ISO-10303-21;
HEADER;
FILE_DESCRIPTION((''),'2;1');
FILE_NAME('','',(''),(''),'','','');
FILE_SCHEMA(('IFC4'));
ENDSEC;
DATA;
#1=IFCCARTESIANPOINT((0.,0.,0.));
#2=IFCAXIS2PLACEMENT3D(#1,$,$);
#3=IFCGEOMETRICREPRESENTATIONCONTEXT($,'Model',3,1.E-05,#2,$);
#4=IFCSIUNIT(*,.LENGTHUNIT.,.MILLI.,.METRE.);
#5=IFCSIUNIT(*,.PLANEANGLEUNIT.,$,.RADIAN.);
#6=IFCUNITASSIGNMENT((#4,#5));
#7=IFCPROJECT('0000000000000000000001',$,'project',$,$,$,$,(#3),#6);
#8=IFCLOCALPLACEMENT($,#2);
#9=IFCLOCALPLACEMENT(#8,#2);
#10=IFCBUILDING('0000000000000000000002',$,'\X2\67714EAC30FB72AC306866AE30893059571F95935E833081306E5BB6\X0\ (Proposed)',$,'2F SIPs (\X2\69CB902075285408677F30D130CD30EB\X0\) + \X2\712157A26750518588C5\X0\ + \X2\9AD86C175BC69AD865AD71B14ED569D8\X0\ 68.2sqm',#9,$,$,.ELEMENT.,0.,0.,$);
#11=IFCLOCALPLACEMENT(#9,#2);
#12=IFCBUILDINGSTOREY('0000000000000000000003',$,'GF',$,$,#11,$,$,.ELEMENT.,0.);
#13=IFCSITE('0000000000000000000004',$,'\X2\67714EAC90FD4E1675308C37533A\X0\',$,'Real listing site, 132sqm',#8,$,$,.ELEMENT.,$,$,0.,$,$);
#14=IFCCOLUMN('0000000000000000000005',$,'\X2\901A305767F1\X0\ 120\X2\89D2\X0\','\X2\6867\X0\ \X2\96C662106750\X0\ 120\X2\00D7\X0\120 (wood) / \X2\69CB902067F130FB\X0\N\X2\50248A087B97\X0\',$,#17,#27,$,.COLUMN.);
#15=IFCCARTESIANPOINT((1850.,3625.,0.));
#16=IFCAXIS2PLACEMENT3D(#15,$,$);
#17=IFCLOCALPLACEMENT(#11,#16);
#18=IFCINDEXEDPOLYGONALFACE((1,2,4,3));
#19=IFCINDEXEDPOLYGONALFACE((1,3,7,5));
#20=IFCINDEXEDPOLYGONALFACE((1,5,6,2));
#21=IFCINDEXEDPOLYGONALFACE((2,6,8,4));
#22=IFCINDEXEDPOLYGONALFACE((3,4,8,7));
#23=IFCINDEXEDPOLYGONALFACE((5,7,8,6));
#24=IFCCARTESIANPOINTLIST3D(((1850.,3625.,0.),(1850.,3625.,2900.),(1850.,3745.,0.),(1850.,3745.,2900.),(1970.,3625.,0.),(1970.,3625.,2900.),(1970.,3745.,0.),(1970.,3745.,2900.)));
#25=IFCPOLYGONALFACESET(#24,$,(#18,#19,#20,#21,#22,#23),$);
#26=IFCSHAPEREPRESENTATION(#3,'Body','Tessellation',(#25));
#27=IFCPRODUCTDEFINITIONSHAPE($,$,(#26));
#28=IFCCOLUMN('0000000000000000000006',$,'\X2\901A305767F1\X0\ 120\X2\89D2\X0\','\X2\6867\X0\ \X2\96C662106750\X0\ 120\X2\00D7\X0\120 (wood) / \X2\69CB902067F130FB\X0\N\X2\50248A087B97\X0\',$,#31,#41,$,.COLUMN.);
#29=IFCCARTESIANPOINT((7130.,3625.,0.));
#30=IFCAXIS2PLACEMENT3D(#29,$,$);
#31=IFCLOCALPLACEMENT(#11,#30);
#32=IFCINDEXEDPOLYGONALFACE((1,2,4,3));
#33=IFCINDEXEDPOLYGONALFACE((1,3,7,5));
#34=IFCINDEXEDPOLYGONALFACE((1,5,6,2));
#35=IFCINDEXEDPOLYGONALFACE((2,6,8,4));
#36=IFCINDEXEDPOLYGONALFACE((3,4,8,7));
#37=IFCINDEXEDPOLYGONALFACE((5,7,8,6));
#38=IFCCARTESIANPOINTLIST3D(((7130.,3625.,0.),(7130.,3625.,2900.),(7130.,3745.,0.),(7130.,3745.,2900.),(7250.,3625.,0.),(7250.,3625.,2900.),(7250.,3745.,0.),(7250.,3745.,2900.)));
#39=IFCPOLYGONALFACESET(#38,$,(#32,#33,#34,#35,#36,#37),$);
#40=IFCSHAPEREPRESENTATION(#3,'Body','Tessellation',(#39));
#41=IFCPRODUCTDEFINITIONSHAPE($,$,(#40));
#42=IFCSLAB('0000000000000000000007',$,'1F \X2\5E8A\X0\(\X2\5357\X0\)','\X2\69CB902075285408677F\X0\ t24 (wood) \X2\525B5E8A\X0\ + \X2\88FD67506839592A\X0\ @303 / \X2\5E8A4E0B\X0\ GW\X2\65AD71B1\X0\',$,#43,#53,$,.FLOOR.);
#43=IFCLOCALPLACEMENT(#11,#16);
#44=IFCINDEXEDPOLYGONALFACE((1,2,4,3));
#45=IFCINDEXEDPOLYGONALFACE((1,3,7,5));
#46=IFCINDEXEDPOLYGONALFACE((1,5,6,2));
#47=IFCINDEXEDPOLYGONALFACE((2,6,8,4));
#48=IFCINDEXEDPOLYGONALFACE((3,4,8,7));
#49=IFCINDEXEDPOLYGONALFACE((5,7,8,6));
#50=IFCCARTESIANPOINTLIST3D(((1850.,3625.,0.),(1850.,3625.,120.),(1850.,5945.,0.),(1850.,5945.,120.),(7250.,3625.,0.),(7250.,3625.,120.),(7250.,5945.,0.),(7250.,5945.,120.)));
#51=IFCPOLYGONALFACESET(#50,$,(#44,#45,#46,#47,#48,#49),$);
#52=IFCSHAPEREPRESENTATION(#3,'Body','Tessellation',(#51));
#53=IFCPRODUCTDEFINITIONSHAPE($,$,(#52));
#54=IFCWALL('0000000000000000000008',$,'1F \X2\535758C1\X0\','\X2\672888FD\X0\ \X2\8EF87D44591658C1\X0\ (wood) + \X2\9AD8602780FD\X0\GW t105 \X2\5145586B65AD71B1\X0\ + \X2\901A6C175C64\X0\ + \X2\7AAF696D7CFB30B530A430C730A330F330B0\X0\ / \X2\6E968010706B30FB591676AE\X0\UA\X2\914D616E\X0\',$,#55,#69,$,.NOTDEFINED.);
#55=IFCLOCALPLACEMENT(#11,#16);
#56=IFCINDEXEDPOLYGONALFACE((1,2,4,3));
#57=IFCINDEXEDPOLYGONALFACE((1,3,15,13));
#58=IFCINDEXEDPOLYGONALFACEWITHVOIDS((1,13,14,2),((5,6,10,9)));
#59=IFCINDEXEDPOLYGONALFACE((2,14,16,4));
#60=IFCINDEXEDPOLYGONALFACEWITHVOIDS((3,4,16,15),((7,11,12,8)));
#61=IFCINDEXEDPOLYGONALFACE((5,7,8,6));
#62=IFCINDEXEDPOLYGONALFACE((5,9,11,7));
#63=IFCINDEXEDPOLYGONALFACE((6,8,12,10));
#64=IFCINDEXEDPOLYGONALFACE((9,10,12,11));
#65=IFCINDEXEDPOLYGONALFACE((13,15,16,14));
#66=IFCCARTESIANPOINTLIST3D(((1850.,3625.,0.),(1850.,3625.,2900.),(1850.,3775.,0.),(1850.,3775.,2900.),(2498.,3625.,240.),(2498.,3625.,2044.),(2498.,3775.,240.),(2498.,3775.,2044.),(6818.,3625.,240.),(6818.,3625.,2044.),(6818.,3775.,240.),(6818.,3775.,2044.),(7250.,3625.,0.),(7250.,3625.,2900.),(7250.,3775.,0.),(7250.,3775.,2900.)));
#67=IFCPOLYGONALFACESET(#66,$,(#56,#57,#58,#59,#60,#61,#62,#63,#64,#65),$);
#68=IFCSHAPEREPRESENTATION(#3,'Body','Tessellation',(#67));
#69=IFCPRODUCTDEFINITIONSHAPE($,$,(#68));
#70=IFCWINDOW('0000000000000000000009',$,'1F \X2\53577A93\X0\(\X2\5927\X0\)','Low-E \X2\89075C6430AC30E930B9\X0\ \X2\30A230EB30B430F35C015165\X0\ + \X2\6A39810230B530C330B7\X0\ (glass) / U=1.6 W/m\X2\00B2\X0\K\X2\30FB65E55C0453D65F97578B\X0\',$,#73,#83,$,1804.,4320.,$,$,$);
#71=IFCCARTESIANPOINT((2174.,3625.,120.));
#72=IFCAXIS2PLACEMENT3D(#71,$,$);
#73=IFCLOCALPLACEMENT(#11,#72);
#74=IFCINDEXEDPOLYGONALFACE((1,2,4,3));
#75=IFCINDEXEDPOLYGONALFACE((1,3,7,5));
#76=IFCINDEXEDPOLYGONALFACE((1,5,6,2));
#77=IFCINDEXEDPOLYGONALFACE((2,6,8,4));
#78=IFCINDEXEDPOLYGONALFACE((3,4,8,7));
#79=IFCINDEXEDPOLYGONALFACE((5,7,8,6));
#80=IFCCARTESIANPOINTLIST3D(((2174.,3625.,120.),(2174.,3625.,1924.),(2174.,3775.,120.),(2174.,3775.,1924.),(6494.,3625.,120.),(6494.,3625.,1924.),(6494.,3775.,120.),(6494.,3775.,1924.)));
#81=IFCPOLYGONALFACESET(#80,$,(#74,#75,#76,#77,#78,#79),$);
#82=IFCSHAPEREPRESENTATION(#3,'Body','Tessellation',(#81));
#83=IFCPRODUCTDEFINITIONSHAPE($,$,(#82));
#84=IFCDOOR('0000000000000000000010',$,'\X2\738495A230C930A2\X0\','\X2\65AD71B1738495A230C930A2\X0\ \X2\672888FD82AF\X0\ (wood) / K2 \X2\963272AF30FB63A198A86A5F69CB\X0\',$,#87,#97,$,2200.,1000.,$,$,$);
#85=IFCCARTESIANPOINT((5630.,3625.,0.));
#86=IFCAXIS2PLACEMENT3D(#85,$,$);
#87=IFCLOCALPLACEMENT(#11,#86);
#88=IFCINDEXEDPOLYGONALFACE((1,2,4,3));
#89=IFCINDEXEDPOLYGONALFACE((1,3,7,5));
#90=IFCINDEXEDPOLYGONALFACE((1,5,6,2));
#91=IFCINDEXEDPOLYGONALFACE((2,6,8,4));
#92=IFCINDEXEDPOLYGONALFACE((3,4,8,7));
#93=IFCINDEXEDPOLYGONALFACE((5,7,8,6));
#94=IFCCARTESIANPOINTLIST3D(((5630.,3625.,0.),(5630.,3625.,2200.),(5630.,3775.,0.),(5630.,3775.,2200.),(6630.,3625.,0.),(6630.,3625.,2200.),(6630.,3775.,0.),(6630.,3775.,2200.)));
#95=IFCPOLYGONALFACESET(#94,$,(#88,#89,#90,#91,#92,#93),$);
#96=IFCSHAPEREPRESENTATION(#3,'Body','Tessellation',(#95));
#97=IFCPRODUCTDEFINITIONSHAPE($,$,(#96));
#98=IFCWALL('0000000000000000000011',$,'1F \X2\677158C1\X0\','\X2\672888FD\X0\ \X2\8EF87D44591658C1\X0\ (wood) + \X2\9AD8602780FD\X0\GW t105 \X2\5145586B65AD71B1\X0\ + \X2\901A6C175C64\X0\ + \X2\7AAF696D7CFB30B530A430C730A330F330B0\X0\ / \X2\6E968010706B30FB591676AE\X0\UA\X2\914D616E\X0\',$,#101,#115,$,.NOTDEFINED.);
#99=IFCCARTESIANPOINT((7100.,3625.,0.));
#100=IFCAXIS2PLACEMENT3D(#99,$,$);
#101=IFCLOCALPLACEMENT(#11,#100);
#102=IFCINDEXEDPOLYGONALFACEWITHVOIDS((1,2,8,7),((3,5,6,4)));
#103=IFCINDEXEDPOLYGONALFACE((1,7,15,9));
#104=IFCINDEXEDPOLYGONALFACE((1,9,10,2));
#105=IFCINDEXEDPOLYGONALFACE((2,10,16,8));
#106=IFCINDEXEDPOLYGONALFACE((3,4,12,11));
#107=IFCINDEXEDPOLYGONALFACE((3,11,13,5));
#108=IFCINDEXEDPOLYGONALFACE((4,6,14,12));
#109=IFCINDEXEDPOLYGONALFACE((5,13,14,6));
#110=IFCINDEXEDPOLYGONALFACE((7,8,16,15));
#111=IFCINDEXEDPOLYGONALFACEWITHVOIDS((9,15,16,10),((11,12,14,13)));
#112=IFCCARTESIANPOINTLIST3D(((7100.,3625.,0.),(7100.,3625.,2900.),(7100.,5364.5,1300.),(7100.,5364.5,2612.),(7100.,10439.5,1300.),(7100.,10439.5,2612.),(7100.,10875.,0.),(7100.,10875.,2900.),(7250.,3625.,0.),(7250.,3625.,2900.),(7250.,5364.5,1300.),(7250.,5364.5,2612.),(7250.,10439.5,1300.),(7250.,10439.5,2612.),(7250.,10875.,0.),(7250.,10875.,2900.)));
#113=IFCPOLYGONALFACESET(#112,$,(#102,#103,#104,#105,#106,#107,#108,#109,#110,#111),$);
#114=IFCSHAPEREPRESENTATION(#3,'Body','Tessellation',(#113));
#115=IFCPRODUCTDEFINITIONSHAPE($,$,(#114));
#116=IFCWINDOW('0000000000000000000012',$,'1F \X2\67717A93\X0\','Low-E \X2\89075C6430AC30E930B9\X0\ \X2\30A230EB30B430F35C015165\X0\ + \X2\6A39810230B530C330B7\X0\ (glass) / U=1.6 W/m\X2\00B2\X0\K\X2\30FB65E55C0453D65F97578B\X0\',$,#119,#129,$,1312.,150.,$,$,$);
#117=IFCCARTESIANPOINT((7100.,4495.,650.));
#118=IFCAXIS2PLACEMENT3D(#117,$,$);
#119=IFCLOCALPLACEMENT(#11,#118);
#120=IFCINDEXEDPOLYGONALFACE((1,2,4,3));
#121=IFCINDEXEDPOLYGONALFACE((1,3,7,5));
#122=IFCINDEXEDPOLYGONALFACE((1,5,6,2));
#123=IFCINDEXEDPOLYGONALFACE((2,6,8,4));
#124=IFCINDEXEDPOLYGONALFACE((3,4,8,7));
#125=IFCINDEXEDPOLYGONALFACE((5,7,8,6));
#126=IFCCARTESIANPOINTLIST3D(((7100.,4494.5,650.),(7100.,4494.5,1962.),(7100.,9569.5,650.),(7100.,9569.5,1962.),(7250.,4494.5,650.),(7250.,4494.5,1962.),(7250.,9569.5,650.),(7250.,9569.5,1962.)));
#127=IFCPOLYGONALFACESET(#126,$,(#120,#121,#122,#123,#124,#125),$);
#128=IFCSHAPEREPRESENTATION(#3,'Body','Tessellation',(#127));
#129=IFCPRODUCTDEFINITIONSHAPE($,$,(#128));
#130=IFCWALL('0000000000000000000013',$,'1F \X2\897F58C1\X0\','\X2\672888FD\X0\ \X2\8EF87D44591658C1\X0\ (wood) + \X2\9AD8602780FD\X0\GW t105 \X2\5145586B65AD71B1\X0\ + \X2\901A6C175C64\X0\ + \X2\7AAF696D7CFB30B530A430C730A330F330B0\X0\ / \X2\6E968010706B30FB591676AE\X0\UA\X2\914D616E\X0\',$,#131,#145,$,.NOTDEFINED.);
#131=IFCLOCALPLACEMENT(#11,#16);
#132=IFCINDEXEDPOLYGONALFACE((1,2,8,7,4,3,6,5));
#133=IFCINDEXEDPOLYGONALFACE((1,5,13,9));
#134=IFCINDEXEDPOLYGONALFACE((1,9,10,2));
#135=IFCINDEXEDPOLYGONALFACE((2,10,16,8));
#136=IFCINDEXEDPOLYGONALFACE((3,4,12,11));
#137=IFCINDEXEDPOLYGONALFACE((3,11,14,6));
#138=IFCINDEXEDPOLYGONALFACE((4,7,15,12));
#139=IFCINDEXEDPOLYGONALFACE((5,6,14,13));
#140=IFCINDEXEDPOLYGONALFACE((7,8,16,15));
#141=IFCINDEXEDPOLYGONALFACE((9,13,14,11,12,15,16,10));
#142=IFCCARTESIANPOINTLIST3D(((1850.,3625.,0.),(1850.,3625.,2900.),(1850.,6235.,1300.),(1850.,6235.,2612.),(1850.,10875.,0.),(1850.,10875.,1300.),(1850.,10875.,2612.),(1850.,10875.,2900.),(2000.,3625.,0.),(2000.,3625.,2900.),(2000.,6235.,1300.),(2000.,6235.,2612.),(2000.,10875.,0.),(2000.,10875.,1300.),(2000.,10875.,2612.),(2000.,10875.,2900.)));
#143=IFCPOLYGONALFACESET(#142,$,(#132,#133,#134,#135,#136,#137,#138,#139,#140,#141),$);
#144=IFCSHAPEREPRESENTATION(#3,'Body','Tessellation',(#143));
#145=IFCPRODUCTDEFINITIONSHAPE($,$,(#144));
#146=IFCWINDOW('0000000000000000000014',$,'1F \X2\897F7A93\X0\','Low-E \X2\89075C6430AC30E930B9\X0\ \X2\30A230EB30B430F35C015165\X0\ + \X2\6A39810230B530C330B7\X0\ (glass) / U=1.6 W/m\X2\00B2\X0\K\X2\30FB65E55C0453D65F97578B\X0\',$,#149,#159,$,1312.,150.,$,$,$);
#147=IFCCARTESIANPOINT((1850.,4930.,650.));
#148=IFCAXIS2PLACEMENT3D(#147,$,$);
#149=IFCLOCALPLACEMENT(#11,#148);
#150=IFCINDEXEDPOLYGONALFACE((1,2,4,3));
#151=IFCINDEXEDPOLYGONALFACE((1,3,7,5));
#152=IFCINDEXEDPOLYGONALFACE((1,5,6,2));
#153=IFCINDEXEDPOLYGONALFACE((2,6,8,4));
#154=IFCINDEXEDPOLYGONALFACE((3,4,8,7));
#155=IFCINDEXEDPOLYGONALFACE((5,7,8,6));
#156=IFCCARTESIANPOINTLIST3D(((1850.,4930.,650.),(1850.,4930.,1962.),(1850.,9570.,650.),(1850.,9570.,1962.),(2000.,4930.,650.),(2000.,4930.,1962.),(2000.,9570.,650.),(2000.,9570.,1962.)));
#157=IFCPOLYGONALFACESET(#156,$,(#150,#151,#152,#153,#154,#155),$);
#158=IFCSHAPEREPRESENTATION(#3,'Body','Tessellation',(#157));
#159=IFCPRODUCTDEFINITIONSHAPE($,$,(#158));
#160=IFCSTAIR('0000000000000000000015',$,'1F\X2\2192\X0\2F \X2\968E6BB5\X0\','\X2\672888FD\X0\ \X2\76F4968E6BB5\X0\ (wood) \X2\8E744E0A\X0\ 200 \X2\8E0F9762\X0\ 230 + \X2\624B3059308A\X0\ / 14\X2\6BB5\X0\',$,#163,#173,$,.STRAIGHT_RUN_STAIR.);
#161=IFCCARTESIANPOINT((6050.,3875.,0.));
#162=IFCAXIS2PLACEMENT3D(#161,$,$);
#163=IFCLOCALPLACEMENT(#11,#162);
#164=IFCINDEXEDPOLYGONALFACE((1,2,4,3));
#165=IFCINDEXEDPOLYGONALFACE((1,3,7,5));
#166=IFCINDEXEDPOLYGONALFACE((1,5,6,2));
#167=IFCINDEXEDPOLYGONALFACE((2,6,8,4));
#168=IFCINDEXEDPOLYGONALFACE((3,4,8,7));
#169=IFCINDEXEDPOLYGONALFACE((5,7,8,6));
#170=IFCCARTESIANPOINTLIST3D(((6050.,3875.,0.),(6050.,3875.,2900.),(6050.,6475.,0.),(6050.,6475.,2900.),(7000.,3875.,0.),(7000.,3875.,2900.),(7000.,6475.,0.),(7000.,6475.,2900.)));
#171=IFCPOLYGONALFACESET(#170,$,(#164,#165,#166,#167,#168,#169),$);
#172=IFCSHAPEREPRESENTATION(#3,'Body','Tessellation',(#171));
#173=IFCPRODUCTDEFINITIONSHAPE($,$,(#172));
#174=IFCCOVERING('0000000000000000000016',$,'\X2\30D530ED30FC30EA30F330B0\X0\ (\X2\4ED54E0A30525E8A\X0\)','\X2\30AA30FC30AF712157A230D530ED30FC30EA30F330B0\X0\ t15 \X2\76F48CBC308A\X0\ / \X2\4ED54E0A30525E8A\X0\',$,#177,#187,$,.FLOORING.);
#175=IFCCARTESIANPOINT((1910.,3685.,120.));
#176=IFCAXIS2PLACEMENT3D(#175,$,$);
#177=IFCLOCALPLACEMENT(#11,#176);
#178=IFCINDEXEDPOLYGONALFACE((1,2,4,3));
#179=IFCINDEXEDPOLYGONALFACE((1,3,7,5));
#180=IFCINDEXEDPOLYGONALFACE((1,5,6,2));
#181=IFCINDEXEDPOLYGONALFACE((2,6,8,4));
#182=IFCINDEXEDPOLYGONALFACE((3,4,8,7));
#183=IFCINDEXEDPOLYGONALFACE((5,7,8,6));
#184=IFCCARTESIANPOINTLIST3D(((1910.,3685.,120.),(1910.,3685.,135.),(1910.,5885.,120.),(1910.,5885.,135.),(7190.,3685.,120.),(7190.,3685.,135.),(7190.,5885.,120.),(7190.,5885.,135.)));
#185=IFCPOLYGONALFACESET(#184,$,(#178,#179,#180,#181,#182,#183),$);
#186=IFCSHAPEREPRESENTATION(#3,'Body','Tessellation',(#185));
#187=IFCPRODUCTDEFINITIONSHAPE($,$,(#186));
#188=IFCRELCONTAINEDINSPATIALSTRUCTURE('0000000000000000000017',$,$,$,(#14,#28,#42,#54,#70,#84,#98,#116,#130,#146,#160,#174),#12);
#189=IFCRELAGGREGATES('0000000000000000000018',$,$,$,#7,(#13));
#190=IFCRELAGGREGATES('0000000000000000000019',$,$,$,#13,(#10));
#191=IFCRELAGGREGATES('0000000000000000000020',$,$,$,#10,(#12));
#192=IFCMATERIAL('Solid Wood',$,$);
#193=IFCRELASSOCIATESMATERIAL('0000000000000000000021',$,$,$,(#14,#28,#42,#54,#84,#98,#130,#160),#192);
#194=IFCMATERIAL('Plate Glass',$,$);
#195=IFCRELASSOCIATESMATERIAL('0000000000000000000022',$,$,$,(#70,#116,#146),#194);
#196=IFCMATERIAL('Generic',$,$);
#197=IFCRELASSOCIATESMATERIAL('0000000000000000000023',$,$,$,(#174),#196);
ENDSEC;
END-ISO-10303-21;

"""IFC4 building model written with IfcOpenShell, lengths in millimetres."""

from ifc_helpers import new_model, si_unit, frame, frame_2d, origin, place, context, project, spatial, rectangle, extrude, material, element, fill, save


model = new_model("IFC4")

# Units and contexts
model_context = context("Model", 3, precision=1e-05, world=origin())
ifc_project = project(units=[si_unit("LENGTHUNIT", "METRE", prefix="MILLI"), si_unit("PLANEANGLEUNIT", "RADIAN")], contexts=[model_context])

# Site, building, storey
site_placement = place(None, origin())
site = spatial("IfcSite", under=ifc_project, at=site_placement, Name="東京都世田谷区", ObjectType="Real listing site, 132sqm", CompositionType="ELEMENT", RefElevation=0.0)
building_placement = place(site_placement, origin())
building = spatial("IfcBuilding", under=site, at=building_placement, Name="東京・犬と暮らす土間広めの家 (Proposed)", ObjectType="2F SIPs (構造用合板パネル) + 無垢材内装 + 高気密高断熱仕様 68.2sqm", CompositionType="ELEMENT", ElevationOfRefHeight=0.0, ElevationOfTerrain=0.0)
storey_placement = place(building_placement, origin())
storey = spatial("IfcBuildingStorey", under=building, at=storey_placement, Name="GF", CompositionType="ELEMENT", Elevation=0.0)

# Columns
ifc_material_1 = material(Name="Solid Wood")
column_1_placement = place(storey_placement, frame((1850.0, 3625.0, 0.0)))
element("IfcColumn", 1, at=column_1_placement, inside=storey, material=ifc_material_1, Name="通し柱 120角", Description="桧 集成材 120×120 (wood) / 構造柱・N値計算", PredefinedType="COLUMN", context=model_context, shape_type="SweptSolid", body=[
    extrude(rectangle(XDim=120.0, YDim=120.0, at=frame_2d((60.0, 60.0))), frame((1850.0, 3625.0, 0.0)), (0.0, 0.0, 1.0), 2900.0),
])
column_2_placement = place(storey_placement, frame((7130.0, 3625.0, 0.0)))
element("IfcColumn", 2, at=column_2_placement, inside=storey, material=ifc_material_1, Name="通し柱 120角", Description="桧 集成材 120×120 (wood) / 構造柱・N値計算", PredefinedType="COLUMN", context=model_context, shape_type="SweptSolid", body=[
    extrude(rectangle(XDim=120.0, YDim=120.0, at=frame_2d((60.0, 60.0))), frame((7130.0, 3625.0, 0.0)), (0.0, 0.0, 1.0), 2900.0),
])

# Slab
slab_1_placement = place(storey_placement, frame((1850.0, 3625.0, 0.0)))
element("IfcSlab", 3, at=slab_1_placement, inside=storey, material=ifc_material_1, Name="1F 床(南)", Description="構造用合板 t24 (wood) 剛床 + 製材根太 @303 / 床下 GW断熱", PredefinedType="FLOOR", context=model_context, shape_type="SweptSolid", body=[
    extrude(rectangle(XDim=5400.0, YDim=2320.0, at=frame_2d((2700.0, 1160.0))), frame((1850.0, 3625.0, 0.0)), (0.0, 0.0, 1.0), 120.0),
])

# Wall, openings, window, door
wall_1_placement = place(storey_placement, frame((1850.0, 3625.0, 0.0)))
wall_1 = element("IfcWall", 4, at=wall_1_placement, inside=storey, material=ifc_material_1, Name="1F 南壁", Description="木製 軸組外壁 (wood) + 高性能GW t105 充填断熱 + 通気層 + 窯業系サイディング / 準耐火・外皮UA配慮", PredefinedType="NOTDEFINED", context=model_context, shape_type="SweptSolid", body=[
    extrude(rectangle(XDim=5400.0, YDim=150.0, at=frame_2d((2700.0, 75.0))), frame((1850.0, 3625.0, 0.0)), (0.0, 0.0, 1.0), 2900.0),
])
opening_1_placement = place(storey_placement, frame((2174.0, 3625.0, 120.0)))
opening_1 = element("IfcOpeningElement", 5, at=opening_1_placement, cuts=wall_1, PredefinedType="NOTDEFINED", context=model_context, shape_type="SweptSolid", body=[
    extrude(rectangle(XDim=4320.0, YDim=150.0, at=frame_2d((2160.0, 75.0))), frame((2174.0, 3625.0, 120.0)), (0.0, 0.0, 1.0), 1804.0),
])
opening_2_placement = place(storey_placement, frame((5630.0, 3625.0, 0.0)))
opening_2 = element("IfcOpeningElement", 6, at=opening_2_placement, cuts=wall_1, PredefinedType="NOTDEFINED", context=model_context, shape_type="SweptSolid", body=[
    extrude(rectangle(XDim=1000.0, YDim=150.0, at=frame_2d((500.0, 75.0))), frame((5630.0, 3625.0, 0.0)), (0.0, 0.0, 1.0), 2200.0),
])
ifc_material_2 = material(Name="Plate Glass")
window_1_placement = place(storey_placement, frame((2174.0, 3625.0, 120.0)))
window_1 = element("IfcWindow", 7, at=window_1_placement, inside=storey, material=ifc_material_2, Name="1F 南窓(大)", Description="Low-E 複層ガラス アルゴン封入 + 樹脂サッシ (glass) / U=1.6 W/m²K・日射取得型", OverallHeight=1804.0, OverallWidth=4320.0, context=model_context, shape_type="SweptSolid", body=[
    extrude(rectangle(XDim=4320.0, YDim=150.0, at=frame_2d((2160.0, 75.0))), frame((2174.0, 3625.0, 120.0)), (0.0, 0.0, 1.0), 1804.0),
])
fill(opening_1, window_1)
door_placement = place(storey_placement, frame((5630.0, 3625.0, 0.0)))
door = element("IfcDoor", 8, at=door_placement, inside=storey, material=ifc_material_1, Name="玄関ドア", Description="断熱玄関ドア 木製芯 (wood) / K2 防犯・採風機構", OverallHeight=2200.0, OverallWidth=1000.0, context=model_context, shape_type="SweptSolid", body=[
    extrude(rectangle(XDim=1000.0, YDim=150.0, at=frame_2d((500.0, 75.0))), frame((5630.0, 3625.0, 0.0)), (0.0, 0.0, 1.0), 2200.0),
])
fill(opening_2, door)

# Walls, openings, windows
wall_2_placement = place(storey_placement, frame((7100.0, 3625.0, 0.0)))
wall_2 = element("IfcWall", 9, at=wall_2_placement, inside=storey, material=ifc_material_1, Name="1F 東壁", Description="木製 軸組外壁 (wood) + 高性能GW t105 充填断熱 + 通気層 + 窯業系サイディング / 準耐火・外皮UA配慮", PredefinedType="NOTDEFINED", context=model_context, shape_type="SweptSolid", body=[
    extrude(rectangle(XDim=150.0, YDim=7250.0, at=frame_2d((75.0, 3625.0))), frame((7100.0, 3625.0, 0.0)), (0.0, 0.0, 1.0), 2900.0),
])
opening_3_placement = place(storey_placement, frame((7100.0, 4495.0, 650.0)))
opening_3 = element("IfcOpeningElement", 10, at=opening_3_placement, cuts=wall_2, PredefinedType="NOTDEFINED", context=model_context, shape_type="SweptSolid", body=[
    extrude(rectangle(XDim=150.0, YDim=5075.0, at=frame_2d((75.0, 2537.0))), frame((7100.0, 4495.0, 650.0)), (0.0, 0.0, 1.0), 1312.0),
])
window_2_placement = place(storey_placement, frame((7100.0, 4495.0, 650.0)))
window_2 = element("IfcWindow", 11, at=window_2_placement, inside=storey, material=ifc_material_2, Name="1F 東窓", Description="Low-E 複層ガラス アルゴン封入 + 樹脂サッシ (glass) / U=1.6 W/m²K・日射取得型", OverallHeight=1312.0, OverallWidth=150.0, context=model_context, shape_type="SweptSolid", body=[
    extrude(rectangle(XDim=150.0, YDim=5075.0, at=frame_2d((75.0, 2537.0))), frame((7100.0, 4495.0, 650.0)), (0.0, 0.0, 1.0), 1312.0),
])
fill(opening_3, window_2)
wall_3_placement = place(storey_placement, frame((1850.0, 3625.0, 0.0)))
wall_3 = element("IfcWall", 12, at=wall_3_placement, inside=storey, material=ifc_material_1, Name="1F 西壁", Description="木製 軸組外壁 (wood) + 高性能GW t105 充填断熱 + 通気層 + 窯業系サイディング / 準耐火・外皮UA配慮", PredefinedType="NOTDEFINED", context=model_context, shape_type="SweptSolid", body=[
    extrude(rectangle(XDim=150.0, YDim=7250.0, at=frame_2d((75.0, 3625.0))), frame((1850.0, 3625.0, 0.0)), (0.0, 0.0, 1.0), 2900.0),
])
opening_4_placement = place(storey_placement, frame((1850.0, 4930.0, 650.0)))
opening_4 = element("IfcOpeningElement", 13, at=opening_4_placement, cuts=wall_3, PredefinedType="NOTDEFINED", context=model_context, shape_type="SweptSolid", body=[
    extrude(rectangle(XDim=150.0, YDim=4640.0, at=frame_2d((75.0, 2320.0))), frame((1850.0, 4930.0, 650.0)), (0.0, 0.0, 1.0), 1312.0),
])
window_3_placement = place(storey_placement, frame((1850.0, 4930.0, 650.0)))
window_3 = element("IfcWindow", 14, at=window_3_placement, inside=storey, material=ifc_material_2, Name="1F 西窓", Description="Low-E 複層ガラス アルゴン封入 + 樹脂サッシ (glass) / U=1.6 W/m²K・日射取得型", OverallHeight=1312.0, OverallWidth=150.0, context=model_context, shape_type="SweptSolid", body=[
    extrude(rectangle(XDim=150.0, YDim=4640.0, at=frame_2d((75.0, 2320.0))), frame((1850.0, 4930.0, 650.0)), (0.0, 0.0, 1.0), 1312.0),
])
fill(opening_4, window_3)

# Stair
stair_placement = place(storey_placement, frame((6050.0, 3875.0, 0.0)))
element("IfcStair", 15, at=stair_placement, inside=storey, material=ifc_material_1, Name="1F→2F 階段", Description="木製 直階段 (wood) 蹴上 200 踏面 230 + 手すり / 14段", PredefinedType="STRAIGHT_RUN_STAIR", context=model_context, shape_type="SweptSolid", body=[
    extrude(rectangle(XDim=950.0, YDim=2600.0, at=frame_2d((475.0, 1300.0))), frame((6050.0, 3875.0, 0.0)), (0.0, 0.0, 1.0), 2900.0),
])

# Covering
ifc_material_3 = material(Name="Generic")
covering_1_placement = place(storey_placement, frame((1910.0, 3685.0, 120.0)))
element("IfcCovering", 16, at=covering_1_placement, inside=storey, material=ifc_material_3, Name="フローリング (仕上げ床)", Description="オーク無垢フローリング t15 直貼り / 仕上げ床", PredefinedType="FLOORING", context=model_context, shape_type="SweptSolid", body=[
    extrude(rectangle(XDim=5280.0, YDim=2200.0, at=frame_2d((2640.0, 1100.0))), frame((1910.0, 3685.0, 120.0)), (0.0, 0.0, 1.0), 15.0),
])

save(model, "model.ifc")
